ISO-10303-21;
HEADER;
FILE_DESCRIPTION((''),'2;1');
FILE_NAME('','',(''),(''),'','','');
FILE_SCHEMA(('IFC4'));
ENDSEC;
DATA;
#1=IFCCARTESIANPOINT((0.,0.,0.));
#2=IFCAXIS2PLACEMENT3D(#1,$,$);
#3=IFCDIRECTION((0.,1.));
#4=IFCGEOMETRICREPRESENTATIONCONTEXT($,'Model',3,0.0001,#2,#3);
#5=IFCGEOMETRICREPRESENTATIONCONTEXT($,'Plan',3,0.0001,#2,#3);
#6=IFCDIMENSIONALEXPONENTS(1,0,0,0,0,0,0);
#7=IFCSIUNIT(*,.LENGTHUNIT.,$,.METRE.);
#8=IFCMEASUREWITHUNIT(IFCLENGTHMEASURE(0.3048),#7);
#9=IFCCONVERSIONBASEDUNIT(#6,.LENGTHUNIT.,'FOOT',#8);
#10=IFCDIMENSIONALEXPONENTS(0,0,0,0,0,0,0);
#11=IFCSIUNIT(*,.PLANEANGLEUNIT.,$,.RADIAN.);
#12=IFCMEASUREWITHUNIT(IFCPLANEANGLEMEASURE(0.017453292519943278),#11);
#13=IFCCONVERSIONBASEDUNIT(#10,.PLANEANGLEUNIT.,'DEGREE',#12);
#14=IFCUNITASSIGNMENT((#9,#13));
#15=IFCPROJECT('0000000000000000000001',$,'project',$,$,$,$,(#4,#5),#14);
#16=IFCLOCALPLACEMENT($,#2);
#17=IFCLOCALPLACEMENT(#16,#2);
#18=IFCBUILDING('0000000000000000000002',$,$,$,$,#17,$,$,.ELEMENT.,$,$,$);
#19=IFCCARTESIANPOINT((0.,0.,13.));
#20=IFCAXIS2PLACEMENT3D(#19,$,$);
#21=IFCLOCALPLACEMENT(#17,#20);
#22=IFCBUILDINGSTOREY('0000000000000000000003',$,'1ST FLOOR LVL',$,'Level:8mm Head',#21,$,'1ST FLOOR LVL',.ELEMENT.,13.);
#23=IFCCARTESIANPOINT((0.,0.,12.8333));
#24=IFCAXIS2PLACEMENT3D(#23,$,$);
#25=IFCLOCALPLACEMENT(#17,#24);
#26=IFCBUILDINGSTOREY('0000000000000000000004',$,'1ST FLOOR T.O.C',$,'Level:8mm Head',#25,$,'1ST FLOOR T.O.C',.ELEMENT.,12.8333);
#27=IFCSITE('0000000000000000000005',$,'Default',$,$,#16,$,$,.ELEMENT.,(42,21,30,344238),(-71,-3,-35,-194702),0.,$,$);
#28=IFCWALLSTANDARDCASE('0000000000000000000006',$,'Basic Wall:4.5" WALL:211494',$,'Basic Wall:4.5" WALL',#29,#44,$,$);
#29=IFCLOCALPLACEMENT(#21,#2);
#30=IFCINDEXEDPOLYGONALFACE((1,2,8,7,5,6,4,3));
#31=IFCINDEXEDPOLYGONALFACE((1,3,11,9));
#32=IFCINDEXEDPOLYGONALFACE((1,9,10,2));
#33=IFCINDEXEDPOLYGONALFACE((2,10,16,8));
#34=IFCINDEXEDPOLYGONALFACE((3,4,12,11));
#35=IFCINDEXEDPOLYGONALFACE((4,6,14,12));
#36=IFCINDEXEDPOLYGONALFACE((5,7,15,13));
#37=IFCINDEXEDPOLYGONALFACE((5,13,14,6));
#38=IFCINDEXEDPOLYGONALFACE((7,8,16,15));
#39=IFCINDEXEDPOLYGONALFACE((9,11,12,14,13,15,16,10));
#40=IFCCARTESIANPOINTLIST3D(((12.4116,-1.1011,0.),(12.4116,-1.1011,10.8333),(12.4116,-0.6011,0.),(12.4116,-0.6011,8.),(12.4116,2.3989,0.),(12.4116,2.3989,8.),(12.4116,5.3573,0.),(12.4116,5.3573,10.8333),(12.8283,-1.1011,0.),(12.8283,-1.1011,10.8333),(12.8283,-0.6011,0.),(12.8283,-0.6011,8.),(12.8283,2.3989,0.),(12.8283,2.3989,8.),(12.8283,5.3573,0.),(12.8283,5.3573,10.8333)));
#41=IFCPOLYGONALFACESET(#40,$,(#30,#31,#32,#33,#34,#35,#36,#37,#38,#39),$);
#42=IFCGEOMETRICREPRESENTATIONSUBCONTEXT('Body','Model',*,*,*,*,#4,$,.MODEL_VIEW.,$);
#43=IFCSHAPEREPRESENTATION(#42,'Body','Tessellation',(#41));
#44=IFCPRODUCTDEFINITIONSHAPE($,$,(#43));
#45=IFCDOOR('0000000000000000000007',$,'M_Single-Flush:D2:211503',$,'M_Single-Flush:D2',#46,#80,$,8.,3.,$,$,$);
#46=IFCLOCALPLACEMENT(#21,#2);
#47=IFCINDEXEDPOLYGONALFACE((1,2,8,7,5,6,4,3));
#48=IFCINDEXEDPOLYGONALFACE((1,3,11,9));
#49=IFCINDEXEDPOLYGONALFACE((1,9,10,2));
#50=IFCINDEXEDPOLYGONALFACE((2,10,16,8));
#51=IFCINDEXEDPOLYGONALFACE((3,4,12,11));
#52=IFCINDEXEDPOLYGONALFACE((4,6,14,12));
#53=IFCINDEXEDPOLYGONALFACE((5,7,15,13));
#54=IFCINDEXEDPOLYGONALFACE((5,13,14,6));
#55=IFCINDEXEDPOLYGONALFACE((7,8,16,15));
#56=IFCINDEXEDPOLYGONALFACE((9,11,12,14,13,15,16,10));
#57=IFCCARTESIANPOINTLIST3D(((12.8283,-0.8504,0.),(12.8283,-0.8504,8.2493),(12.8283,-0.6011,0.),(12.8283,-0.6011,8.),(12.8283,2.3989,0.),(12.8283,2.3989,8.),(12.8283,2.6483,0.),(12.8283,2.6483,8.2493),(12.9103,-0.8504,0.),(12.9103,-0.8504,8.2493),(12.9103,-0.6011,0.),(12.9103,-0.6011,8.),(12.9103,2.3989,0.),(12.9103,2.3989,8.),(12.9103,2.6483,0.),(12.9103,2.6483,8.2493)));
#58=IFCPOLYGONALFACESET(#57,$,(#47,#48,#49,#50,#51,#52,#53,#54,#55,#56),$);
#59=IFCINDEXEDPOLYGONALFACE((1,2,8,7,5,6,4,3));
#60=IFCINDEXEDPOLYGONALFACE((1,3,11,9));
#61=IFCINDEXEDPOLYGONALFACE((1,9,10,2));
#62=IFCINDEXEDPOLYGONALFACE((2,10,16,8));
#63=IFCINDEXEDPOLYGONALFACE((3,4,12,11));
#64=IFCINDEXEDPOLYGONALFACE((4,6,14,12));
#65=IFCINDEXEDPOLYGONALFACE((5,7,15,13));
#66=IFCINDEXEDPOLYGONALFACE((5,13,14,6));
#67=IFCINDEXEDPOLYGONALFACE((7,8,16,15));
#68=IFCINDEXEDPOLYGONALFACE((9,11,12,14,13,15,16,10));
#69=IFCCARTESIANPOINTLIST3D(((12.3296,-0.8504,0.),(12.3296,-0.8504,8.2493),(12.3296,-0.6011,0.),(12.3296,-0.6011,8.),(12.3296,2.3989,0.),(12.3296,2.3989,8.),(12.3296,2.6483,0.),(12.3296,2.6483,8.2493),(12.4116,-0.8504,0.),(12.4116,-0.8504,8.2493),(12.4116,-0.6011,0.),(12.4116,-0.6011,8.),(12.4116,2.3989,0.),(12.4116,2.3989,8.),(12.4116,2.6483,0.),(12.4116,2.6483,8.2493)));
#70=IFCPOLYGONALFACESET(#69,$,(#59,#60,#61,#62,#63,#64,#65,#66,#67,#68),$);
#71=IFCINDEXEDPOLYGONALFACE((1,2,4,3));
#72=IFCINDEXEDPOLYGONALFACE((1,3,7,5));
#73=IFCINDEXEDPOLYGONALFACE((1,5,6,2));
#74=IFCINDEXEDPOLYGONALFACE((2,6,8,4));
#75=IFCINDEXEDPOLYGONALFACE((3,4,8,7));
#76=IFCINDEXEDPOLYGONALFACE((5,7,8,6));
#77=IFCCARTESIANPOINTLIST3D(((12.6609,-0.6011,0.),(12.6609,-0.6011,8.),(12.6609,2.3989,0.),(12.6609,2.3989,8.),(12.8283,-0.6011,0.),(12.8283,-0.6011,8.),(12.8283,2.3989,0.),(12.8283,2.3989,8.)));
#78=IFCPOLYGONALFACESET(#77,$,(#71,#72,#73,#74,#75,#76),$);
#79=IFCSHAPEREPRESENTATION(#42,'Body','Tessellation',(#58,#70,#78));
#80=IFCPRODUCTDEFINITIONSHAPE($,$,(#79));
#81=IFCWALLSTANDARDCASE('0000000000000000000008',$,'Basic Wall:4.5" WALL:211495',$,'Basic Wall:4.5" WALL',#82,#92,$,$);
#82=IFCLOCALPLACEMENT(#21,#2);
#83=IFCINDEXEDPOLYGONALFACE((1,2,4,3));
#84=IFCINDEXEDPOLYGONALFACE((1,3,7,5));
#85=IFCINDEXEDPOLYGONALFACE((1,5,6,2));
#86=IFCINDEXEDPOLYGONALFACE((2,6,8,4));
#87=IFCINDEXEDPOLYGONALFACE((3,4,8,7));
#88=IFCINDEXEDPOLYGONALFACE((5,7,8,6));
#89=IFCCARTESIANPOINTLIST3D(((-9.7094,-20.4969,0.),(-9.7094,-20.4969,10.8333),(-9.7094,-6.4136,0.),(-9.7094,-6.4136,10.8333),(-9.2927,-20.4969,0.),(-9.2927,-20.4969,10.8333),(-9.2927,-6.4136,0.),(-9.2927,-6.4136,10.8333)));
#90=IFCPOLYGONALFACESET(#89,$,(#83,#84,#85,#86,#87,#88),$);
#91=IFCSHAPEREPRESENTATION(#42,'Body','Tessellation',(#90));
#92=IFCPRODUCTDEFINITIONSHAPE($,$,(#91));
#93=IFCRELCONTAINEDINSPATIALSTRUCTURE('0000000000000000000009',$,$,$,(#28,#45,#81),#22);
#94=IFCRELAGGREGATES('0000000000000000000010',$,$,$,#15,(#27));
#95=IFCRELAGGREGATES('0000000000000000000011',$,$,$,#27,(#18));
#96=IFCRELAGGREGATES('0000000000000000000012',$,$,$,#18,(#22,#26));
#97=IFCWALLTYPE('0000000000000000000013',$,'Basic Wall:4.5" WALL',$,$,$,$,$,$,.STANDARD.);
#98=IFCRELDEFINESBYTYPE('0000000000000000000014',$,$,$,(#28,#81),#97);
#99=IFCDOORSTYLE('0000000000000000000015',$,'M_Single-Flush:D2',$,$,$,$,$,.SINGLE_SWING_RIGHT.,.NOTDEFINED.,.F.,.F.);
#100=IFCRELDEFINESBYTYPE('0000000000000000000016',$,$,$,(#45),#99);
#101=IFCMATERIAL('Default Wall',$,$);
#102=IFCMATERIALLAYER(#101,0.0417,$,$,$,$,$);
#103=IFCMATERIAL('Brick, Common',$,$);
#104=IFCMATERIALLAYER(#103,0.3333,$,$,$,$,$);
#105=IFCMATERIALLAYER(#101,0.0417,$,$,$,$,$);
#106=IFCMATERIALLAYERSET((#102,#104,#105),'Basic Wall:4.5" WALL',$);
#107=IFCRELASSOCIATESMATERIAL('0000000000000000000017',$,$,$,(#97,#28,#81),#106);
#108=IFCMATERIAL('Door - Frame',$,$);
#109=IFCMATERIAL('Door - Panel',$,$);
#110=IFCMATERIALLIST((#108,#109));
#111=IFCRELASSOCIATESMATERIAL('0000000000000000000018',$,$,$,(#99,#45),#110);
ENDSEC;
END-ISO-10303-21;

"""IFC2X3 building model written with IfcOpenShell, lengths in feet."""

from ifc_helpers import new_model, entity, si_unit, converted_unit, direction, frame, frame_2d, origin, place, context, subcontext, project, spatial, polyline, rectangle, outline, extrude, source, transform, mapped, material, material_list, layer, layer_set, layer_usage, type_object, type_shapes, element, fill, save


model = new_model("IFC2X3")

# Units and contexts
model_context = context("Model", 3, precision=0.0001, world=origin(), true_north=direction((0.0, 1.0)))
plan_context = context("Plan", 3, precision=0.0001, world=origin(), true_north=direction((0.0, 1.0)))
body_context = subcontext(model_context, "Body", "Model", "MODEL_VIEW")
ifc_project = project(units=[converted_unit("LENGTHUNIT", "FOOT", entity("IfcLengthMeasure", 0.3048), si_unit("LENGTHUNIT", "METRE"), dimensions=[1, 0, 0, 0, 0, 0, 0]), converted_unit("PLANEANGLEUNIT", "DEGREE", entity("IfcPlaneAngleMeasure", 0.017453292519943278), si_unit("PLANEANGLEUNIT", "RADIAN"), dimensions=[0, 0, 0, 0, 0, 0, 0])], contexts=[model_context, plan_context])

# Site, building, storey
site_placement = place(None, origin())
site = spatial("IfcSite", under=ifc_project, at=site_placement, Name="Default", CompositionType="ELEMENT", RefLatitude=(42, 21, 30, 344238), RefLongitude=(-71, -3, -35, -194702), RefElevation=0.0)
building_placement = place(site_placement, origin())
building = spatial("IfcBuilding", under=site, at=building_placement, CompositionType="ELEMENT")
storey_1_placement = place(building_placement, frame((0.0, 0.0, 13.0)))
storey_1 = spatial("IfcBuildingStorey", under=building, at=storey_1_placement, Name="1ST FLOOR LVL", ObjectType="Level:8mm Head", LongName="1ST FLOOR LVL", CompositionType="ELEMENT", Elevation=13.0)

# Shared definitions
ifc_material_1 = material(Name="Default Wall")
ifc_material_2 = material(Name="Brick, Common")

# Shared definitions
storey_2_placement = place(building_placement, frame((0.0, 0.0, 12.8333)))
storey_2 = spatial("IfcBuildingStorey", under=building, at=storey_2_placement, Name="1ST FLOOR T.O.C", ObjectType="Level:8mm Head", LongName="1ST FLOOR T.O.C", CompositionType="ELEMENT", Elevation=12.8333)

# Shared definitions
ifc_material_3 = material(Name="Door - Frame")
ifc_material_4 = material(Name="Door - Panel")
ifc_material_list_1 = material_list([ifc_material_3, ifc_material_4])

# Shared definitions
ifc_layer_1 = layer(ifc_material_1, 0.0417)
ifc_layer_2 = layer(ifc_material_2, 0.3333)
ifc_layer_3 = layer(ifc_material_1, 0.0417)
ifc_layer_set_1 = layer_set([ifc_layer_1, ifc_layer_2, ifc_layer_3], Name="Basic Wall:4.5\" WALL")
wall_type_1 = type_object("IfcWallType", Name="Basic Wall:4.5\" WALL", PredefinedType="STANDARD", material=ifc_layer_set_1)

# Wall, opening, door
ifc_layer_usage_1 = layer_usage(ifc_layer_set_1, "AXIS2", "NEGATIVE", 0.2083)
wall_1_placement = place(storey_1_placement, frame((12.6199, 5.3573, 0.0), z_axis=(0.0, 0.0, 1.0), x_axis=(0.0, -1.0, 0.0)))
wall_1 = element("IfcWallStandardCase", 1, at=wall_1_placement, inside=storey_1, type_object=wall_type_1, material=ifc_layer_usage_1, Name="Basic Wall:4.5\" WALL:211494", ObjectType="Basic Wall:4.5\" WALL", context=body_context, shape_type="SweptSolid", body=[
    extrude(rectangle(XDim=6.4583, YDim=0.4167, at=frame_2d((3.2292, 0.0), x_axis=(-1.0, 0.0))), origin(), (0.0, 0.0, 1.0), 10.8333),
])
opening_1_placement = place(wall_1_placement, frame((2.9583, -0.2083, 0.0)))
opening_1 = element("IfcOpeningElement", 2, at=opening_1_placement, cuts=wall_1, ObjectType="Opening", context=body_context, shape_type="SweptSolid", body=[
    extrude(rectangle(XDim=3.0, YDim=8.0, at=frame_2d((4.0, 1.5), x_axis=(0.0, 1.0))), frame((0.0, 0.0, 0.0), z_axis=(0.0, 1.0, 0.0), x_axis=(0.0, 0.0, 1.0)), (0.0, 0.0, 1.0), 0.4167),
])
door_style_1 = type_object("IfcDoorStyle", Name="M_Single-Flush:D2", ConstructionType="NOTDEFINED", OperationType="SINGLE_SWING_RIGHT", ParameterTakesPrecedence=False, Sizeable=False, material=ifc_material_list_1)
shared_shape_1 = source(origin(), body_context, "Body", "SweptSolid", [
    extrude(outline(polyline([(-1.7493, -4.187), (1.7493, -4.187), (1.7493, 4.0623), (1.5, 4.0623), (1.5, -3.9377), (-1.5, -3.9377), (-1.5, 4.0623), (-1.7493, 4.0623), (-1.7493, -4.187)])), frame((1.5, 0.4167, 4.0623), z_axis=(0.0, 1.0, 0.0), x_axis=(1.0, 0.0, 0.0)), (0.0, 0.0, 1.0), 0.082),
    extrude(outline(polyline([(-4.187, -1.7493), (4.0623, -1.7493), (4.0623, -1.5), (-3.9377, -1.5), (-3.9377, 1.5), (4.0623, 1.5), (4.0623, 1.7493), (-4.187, 1.7493), (-4.187, -1.7493)])), frame((1.5, -0.082, 4.0623), z_axis=(0.0, 1.0, 0.0), x_axis=(0.0, 0.0, -1.0)), (0.0, 0.0, 1.0), 0.082),
    extrude(rectangle(XDim=0.1673, YDim=3.0, at=frame_2d((0.0, 0.0), x_axis=(1.0, 0.0))), frame((1.5, 0.333, 0.0), z_axis=(0.0, 0.0, 1.0), x_axis=(0.0, 1.0, 0.0)), (0.0, 0.0, 1.0), 8.0),
])
type_shapes(door_style_1, [shared_shape_1])
door_1_placement = place(opening_1_placement, origin())
door_1 = element("IfcDoor", 3, at=door_1_placement, inside=storey_1, type_object=door_style_1, material=ifc_material_list_1, Name="M_Single-Flush:D2:211503", ObjectType="M_Single-Flush:D2", OverallHeight=8.0, OverallWidth=3.0, context=body_context, shape_type="MappedRepresentation", body=[
    mapped(shared_shape_1, transform((0.0, 0.0, 0.0), scale=1.0)),
])
fill(opening_1, door_1)

# Wall
ifc_layer_usage_2 = layer_usage(ifc_layer_set_1, "AXIS2", "NEGATIVE", 0.2083)
wall_2_placement = place(storey_1_placement, frame((-9.5011, -20.4969, 0.0), z_axis=(0.0, 0.0, 1.0), x_axis=(0.0, 1.0, 0.0)))
element("IfcWallStandardCase", 4, at=wall_2_placement, inside=storey_1, type_object=wall_type_1, material=ifc_layer_usage_2, Name="Basic Wall:4.5\" WALL:211495", ObjectType="Basic Wall:4.5\" WALL", context=body_context, shape_type="SweptSolid", body=[
    extrude(rectangle(XDim=14.0833, YDim=0.4167, at=frame_2d((7.0417, 0.0), x_axis=(-1.0, 0.0))), origin(), (0.0, 0.0, 1.0), 10.8333),
])

save(model, "model.ifc")
